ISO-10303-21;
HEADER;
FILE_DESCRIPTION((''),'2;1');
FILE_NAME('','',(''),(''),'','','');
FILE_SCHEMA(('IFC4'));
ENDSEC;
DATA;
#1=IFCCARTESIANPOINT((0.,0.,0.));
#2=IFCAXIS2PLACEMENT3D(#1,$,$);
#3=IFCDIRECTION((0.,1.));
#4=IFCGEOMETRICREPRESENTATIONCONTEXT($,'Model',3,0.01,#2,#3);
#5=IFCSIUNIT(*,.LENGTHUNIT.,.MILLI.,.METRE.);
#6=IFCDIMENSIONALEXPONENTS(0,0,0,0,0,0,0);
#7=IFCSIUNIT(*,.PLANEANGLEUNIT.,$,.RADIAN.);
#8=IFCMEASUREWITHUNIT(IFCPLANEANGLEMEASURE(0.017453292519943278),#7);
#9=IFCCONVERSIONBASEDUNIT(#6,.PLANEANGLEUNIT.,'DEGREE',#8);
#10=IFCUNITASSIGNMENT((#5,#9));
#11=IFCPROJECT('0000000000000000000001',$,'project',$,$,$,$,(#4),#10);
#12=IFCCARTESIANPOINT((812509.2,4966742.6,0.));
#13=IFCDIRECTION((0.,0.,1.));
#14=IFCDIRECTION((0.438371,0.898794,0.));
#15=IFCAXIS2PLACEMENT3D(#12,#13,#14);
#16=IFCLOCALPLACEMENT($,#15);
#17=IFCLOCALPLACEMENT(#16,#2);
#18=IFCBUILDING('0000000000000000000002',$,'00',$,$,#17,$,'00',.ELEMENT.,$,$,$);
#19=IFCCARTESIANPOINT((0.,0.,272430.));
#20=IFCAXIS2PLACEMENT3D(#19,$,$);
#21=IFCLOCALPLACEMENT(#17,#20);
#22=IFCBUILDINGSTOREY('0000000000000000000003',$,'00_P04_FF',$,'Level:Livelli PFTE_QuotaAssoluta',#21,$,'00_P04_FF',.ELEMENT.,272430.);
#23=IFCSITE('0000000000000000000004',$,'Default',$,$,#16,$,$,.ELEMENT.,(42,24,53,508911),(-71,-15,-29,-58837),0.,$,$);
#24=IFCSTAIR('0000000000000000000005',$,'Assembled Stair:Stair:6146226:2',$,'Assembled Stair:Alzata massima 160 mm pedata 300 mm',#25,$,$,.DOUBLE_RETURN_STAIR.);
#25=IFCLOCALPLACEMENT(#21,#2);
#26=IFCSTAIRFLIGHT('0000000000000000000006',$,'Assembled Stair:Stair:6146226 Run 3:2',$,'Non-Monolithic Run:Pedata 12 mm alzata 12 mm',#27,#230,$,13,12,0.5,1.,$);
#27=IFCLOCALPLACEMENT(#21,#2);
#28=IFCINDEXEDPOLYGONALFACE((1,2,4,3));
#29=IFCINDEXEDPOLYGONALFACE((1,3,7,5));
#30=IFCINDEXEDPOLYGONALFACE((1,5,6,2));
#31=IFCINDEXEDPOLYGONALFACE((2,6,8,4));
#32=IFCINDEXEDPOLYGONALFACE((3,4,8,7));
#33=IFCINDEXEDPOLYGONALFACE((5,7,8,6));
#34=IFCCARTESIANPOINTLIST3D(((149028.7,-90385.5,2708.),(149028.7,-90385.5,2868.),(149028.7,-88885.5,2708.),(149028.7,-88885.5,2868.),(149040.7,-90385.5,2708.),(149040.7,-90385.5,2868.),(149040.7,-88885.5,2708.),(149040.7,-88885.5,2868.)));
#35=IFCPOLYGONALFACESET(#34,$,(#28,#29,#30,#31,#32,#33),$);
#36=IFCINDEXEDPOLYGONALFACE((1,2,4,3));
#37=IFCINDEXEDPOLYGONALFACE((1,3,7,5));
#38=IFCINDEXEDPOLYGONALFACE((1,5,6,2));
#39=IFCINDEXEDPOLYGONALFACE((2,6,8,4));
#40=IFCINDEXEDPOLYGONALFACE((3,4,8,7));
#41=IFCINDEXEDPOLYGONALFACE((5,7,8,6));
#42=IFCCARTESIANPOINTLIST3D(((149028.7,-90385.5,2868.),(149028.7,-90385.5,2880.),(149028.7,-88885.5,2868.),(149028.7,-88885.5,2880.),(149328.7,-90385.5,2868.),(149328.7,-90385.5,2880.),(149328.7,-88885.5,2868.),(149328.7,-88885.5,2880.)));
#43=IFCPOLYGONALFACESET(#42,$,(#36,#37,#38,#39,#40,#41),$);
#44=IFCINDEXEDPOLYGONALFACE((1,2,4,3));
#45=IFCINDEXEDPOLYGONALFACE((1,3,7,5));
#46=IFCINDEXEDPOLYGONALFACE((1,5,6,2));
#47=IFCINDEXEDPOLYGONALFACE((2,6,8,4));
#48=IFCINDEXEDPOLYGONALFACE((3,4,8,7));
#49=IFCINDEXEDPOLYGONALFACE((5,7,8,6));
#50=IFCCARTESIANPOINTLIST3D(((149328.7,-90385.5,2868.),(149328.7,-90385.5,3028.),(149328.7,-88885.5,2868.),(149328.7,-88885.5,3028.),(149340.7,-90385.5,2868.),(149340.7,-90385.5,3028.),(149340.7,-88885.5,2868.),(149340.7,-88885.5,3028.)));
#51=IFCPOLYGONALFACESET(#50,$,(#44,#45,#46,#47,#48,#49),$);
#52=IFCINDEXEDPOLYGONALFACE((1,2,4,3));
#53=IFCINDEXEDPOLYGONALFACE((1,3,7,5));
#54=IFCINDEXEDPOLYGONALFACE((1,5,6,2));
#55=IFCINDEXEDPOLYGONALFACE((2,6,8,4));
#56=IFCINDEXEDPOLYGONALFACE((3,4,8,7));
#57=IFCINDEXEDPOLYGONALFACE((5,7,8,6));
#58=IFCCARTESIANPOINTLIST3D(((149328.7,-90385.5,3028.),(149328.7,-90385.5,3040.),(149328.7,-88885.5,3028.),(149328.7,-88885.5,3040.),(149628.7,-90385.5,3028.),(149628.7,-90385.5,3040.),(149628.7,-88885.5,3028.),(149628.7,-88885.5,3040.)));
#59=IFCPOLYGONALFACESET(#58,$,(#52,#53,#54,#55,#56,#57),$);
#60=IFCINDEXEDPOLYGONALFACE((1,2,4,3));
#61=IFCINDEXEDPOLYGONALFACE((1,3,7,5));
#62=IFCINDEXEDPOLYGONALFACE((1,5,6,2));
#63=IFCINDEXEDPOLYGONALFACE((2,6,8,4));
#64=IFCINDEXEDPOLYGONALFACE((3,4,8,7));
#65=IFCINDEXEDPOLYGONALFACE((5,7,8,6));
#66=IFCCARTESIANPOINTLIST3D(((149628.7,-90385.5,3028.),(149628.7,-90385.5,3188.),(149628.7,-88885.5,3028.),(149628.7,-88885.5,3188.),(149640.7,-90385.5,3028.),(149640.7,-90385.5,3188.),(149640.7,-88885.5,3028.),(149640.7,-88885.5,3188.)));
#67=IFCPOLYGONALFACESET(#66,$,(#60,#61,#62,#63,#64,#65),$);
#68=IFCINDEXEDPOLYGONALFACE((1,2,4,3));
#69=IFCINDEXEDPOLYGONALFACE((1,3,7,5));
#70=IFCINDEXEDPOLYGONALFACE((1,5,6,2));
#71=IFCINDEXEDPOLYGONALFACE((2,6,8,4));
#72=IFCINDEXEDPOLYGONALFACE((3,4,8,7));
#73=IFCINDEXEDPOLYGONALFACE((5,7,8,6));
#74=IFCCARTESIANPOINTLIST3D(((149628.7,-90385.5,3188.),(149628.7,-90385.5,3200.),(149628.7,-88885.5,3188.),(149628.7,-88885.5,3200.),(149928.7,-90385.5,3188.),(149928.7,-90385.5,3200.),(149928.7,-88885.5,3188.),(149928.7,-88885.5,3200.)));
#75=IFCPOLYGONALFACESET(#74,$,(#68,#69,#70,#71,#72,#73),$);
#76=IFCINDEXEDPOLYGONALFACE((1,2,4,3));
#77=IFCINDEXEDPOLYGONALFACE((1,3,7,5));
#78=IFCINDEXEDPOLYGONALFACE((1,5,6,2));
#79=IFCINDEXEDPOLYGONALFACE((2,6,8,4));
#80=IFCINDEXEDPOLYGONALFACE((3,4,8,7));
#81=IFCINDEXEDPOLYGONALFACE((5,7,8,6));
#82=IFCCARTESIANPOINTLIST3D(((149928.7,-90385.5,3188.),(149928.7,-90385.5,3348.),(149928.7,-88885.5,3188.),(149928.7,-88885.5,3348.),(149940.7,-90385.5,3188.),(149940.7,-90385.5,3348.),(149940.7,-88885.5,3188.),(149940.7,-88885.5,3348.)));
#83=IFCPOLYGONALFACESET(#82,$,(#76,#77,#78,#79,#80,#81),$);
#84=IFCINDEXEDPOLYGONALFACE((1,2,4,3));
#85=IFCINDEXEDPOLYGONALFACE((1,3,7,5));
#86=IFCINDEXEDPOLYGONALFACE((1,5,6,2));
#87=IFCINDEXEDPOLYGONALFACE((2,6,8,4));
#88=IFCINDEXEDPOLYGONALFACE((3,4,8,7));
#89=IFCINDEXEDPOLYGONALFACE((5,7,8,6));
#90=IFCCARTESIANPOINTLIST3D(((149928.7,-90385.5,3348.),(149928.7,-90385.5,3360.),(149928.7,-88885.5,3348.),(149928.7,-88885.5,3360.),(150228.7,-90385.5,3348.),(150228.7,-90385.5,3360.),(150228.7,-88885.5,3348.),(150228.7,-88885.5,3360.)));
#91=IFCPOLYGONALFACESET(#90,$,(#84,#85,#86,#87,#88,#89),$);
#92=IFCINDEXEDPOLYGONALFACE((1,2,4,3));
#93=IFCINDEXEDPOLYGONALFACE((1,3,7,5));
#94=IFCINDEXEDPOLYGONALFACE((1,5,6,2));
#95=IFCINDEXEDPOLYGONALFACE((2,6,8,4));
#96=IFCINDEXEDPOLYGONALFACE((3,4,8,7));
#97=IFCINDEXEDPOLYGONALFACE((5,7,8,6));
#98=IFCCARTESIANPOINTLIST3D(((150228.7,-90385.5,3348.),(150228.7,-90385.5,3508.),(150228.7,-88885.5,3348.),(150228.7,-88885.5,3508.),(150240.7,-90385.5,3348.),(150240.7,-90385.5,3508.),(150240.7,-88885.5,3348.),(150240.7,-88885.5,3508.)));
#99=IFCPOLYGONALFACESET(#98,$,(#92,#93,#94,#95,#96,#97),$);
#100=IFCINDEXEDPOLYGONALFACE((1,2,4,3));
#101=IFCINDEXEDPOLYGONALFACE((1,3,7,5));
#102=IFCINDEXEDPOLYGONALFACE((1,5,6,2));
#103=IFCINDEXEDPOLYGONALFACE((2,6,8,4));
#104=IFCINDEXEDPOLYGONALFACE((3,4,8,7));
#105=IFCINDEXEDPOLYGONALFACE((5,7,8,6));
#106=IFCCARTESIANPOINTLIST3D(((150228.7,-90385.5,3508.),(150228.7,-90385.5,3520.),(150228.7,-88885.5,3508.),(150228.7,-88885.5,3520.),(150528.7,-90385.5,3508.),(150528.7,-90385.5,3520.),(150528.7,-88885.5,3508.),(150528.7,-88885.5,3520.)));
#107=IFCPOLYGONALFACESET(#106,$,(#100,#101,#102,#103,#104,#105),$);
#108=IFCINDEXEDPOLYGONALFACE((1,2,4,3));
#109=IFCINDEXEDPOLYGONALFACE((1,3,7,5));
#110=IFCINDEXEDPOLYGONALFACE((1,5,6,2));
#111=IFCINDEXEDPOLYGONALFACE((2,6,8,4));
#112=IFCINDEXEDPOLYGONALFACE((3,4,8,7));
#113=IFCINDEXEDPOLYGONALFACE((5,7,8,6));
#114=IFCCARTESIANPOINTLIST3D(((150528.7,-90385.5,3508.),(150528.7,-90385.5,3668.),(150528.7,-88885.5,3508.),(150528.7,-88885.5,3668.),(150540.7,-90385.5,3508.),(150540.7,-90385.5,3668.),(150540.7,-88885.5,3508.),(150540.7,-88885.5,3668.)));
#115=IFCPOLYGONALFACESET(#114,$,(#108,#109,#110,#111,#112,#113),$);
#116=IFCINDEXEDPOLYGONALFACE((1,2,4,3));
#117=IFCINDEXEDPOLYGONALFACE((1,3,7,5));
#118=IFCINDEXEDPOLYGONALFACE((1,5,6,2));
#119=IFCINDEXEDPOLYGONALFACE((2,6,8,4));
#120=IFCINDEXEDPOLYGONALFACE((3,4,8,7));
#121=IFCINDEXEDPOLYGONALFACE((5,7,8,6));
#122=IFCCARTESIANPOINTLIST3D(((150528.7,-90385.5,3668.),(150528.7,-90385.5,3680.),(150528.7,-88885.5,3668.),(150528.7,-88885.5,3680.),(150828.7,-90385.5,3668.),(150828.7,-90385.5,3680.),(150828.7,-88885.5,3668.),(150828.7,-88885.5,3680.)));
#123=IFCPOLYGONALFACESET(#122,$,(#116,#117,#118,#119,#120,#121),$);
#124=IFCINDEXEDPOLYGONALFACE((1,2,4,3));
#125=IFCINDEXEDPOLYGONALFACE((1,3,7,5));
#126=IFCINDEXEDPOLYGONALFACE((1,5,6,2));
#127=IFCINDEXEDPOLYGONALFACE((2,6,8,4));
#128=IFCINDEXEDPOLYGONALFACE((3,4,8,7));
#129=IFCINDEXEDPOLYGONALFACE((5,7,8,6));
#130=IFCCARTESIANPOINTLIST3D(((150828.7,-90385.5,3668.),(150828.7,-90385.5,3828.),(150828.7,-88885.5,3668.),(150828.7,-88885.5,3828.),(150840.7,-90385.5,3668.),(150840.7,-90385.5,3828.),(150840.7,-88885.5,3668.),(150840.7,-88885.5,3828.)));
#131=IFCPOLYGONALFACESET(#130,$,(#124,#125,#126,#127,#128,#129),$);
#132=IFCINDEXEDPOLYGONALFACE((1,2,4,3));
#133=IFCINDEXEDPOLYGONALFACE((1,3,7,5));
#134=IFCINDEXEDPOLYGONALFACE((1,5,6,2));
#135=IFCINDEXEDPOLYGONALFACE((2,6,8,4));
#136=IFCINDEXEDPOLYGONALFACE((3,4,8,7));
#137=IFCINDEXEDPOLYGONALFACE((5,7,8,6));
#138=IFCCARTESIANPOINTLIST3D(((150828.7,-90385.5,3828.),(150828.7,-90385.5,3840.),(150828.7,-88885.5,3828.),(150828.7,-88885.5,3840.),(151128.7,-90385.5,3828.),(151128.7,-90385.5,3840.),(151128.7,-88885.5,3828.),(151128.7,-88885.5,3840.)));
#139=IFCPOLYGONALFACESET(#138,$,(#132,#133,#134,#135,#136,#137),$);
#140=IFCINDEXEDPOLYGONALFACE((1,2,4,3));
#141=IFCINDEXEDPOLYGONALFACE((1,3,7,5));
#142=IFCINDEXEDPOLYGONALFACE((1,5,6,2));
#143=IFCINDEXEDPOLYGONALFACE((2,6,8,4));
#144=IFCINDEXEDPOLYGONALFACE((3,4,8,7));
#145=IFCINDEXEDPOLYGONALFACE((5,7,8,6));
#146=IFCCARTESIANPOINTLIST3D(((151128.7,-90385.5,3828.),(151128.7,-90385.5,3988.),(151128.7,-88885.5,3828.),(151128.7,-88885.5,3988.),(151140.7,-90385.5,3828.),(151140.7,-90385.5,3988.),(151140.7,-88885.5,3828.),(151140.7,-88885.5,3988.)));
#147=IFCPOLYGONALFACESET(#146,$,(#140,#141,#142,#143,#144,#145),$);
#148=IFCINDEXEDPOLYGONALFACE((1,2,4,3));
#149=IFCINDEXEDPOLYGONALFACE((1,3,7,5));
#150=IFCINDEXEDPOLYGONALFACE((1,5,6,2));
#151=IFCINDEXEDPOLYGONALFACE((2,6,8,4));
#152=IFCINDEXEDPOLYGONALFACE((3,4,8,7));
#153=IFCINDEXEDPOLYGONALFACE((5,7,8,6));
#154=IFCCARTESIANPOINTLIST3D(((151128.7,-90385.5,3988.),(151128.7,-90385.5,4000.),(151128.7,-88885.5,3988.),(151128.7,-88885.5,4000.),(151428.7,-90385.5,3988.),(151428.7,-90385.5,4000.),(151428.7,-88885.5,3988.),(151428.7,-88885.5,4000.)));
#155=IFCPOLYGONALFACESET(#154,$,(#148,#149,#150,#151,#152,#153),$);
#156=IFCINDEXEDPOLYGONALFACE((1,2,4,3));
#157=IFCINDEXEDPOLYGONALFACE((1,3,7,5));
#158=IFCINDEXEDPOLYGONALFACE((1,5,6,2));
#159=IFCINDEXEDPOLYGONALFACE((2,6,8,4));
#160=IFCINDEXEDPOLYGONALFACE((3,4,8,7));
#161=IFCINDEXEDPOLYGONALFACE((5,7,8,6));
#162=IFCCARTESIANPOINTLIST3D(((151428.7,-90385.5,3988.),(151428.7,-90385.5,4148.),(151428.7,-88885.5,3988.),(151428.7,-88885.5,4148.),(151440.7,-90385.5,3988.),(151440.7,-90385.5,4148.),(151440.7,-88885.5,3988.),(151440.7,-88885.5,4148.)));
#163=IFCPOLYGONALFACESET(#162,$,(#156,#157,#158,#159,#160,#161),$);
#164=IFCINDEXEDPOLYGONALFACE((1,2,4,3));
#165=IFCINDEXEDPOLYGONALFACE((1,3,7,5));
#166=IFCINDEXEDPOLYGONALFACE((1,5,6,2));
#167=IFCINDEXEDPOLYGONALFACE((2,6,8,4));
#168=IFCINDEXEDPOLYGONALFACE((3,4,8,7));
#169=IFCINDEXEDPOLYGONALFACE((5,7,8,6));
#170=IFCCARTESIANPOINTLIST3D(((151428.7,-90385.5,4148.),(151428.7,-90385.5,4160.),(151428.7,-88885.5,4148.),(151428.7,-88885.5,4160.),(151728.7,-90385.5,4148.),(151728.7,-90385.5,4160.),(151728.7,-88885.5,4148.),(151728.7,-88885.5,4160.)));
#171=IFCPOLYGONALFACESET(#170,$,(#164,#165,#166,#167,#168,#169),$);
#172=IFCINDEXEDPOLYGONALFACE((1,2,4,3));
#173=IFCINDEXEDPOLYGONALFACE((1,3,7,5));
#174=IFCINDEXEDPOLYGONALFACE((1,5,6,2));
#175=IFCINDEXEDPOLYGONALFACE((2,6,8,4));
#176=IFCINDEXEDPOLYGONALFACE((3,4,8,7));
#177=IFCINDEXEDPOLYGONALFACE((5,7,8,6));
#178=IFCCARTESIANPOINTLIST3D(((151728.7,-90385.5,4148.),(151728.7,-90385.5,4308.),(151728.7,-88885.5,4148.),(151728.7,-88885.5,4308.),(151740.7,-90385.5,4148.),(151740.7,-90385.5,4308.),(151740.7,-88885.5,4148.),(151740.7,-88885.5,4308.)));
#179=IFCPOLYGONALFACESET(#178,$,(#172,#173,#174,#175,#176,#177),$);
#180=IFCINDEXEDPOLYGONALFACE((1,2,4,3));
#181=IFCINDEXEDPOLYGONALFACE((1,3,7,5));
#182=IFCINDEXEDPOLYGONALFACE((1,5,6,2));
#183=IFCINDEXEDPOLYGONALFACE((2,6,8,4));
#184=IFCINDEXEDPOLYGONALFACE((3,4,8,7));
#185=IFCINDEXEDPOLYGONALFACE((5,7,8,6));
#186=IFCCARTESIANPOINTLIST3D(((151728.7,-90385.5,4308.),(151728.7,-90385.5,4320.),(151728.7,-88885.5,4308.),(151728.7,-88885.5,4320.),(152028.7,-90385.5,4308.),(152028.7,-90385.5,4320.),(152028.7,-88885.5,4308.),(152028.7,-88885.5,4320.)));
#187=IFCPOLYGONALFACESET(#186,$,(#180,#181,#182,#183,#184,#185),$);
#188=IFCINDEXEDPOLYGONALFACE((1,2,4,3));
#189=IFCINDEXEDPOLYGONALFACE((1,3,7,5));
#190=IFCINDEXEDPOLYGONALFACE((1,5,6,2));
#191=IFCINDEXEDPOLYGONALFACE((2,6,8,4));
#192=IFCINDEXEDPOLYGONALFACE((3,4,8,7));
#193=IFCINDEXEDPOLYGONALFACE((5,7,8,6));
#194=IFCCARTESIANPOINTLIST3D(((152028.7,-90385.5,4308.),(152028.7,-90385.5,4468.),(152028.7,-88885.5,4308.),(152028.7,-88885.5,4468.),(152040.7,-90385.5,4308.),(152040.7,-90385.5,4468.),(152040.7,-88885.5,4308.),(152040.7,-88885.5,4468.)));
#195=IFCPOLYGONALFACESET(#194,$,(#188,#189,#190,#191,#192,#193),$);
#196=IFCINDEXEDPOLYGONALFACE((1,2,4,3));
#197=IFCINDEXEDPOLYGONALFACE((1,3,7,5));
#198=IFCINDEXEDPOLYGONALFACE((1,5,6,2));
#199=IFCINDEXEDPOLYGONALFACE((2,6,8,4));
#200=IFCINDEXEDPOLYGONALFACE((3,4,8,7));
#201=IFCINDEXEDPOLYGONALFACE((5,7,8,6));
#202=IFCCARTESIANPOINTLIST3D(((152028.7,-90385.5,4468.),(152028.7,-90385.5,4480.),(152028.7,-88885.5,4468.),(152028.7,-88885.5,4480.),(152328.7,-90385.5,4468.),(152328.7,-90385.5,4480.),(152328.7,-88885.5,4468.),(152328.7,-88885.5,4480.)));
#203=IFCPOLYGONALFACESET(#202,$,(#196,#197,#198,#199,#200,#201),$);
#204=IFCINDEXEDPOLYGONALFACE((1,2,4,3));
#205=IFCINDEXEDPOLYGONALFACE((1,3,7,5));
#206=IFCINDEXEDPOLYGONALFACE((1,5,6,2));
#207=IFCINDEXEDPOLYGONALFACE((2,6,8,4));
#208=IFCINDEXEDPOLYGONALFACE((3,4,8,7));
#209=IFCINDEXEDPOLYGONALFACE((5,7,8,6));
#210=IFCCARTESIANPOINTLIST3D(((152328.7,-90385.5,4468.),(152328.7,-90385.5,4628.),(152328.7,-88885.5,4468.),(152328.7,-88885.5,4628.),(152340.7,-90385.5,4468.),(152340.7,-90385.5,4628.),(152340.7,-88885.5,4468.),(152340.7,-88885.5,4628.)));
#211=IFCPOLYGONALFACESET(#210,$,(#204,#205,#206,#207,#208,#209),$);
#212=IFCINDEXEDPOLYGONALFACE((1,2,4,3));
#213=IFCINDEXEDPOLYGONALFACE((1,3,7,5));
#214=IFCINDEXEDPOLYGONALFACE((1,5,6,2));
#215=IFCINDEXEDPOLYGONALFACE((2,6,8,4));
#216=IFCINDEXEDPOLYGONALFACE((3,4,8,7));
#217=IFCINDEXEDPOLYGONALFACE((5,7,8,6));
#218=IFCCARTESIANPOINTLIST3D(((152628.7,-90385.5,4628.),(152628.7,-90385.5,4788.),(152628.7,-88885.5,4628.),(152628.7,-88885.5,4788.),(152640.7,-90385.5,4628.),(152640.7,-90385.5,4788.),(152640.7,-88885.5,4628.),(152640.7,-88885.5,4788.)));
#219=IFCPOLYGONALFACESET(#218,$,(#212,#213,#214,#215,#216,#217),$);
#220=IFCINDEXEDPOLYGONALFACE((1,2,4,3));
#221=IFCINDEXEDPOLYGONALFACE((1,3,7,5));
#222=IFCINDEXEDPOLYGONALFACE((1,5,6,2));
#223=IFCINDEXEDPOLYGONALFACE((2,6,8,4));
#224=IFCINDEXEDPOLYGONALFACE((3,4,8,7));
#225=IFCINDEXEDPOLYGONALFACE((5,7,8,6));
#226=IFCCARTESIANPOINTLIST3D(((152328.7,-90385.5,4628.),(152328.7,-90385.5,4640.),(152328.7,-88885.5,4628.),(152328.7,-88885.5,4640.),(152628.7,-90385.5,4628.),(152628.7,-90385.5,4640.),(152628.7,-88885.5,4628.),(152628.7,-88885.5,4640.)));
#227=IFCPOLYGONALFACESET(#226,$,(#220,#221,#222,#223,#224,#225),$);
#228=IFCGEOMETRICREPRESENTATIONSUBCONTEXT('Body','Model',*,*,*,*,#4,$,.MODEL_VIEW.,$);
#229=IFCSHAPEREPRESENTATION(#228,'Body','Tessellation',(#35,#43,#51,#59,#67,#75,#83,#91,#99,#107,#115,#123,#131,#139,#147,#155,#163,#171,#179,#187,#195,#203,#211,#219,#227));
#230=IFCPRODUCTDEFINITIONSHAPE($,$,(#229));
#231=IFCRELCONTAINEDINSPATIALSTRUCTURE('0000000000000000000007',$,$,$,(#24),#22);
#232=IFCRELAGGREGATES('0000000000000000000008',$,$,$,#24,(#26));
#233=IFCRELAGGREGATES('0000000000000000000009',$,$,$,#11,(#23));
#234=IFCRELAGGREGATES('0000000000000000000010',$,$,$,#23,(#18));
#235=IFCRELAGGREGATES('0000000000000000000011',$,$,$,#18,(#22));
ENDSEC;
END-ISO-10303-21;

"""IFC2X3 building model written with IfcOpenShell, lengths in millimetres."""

from ifc_helpers import new_model, entity, si_unit, converted_unit, direction, frame, origin, origin_2d_with_axis, place, context, subcontext, project, spatial, rectangle, extrude, element, aggregate, save


model = new_model("IFC2X3")

# Units and contexts
model_context = context("Model", 3, precision=0.01, world=origin(), true_north=direction((0.0, 1.0)))
body_context = subcontext(model_context, "Body", "Model", "MODEL_VIEW")
ifc_project = project(units=[si_unit("LENGTHUNIT", "METRE", prefix="MILLI"), converted_unit("PLANEANGLEUNIT", "DEGREE", entity("IfcPlaneAngleMeasure", 0.017453292519943278), si_unit("PLANEANGLEUNIT", "RADIAN"), dimensions=[0, 0, 0, 0, 0, 0, 0])], contexts=[model_context])

# Site, building, storey
site_placement = place(None, frame((812509.2, 4966742.6, 0.0), z_axis=(0.0, 0.0, 1.0), x_axis=(0.438371, 0.898794, 0.0)))
site = spatial("IfcSite", under=ifc_project, at=site_placement, Name="Default", CompositionType="ELEMENT", RefLatitude=(42, 24, 53, 508911), RefLongitude=(-71, -15, -29, -58837), RefElevation=0.0)
building_placement = place(site_placement, origin())
building = spatial("IfcBuilding", under=site, at=building_placement, Name="00", LongName="00", CompositionType="ELEMENT")
storey_placement = place(building_placement, frame((0.0, 0.0, 272430.0)))
storey = spatial("IfcBuildingStorey", under=building, at=storey_placement, Name="00_P04_FF", ObjectType="Level:Livelli PFTE_QuotaAssoluta", LongName="00_P04_FF", CompositionType="ELEMENT", Elevation=272430.0)

# Stair
stair_1_placement = place(storey_placement, origin())
stair_1 = element("IfcStair", 1, at=stair_1_placement, inside=storey, Name="Assembled Stair:Stair:6146226:2", ObjectType="Assembled Stair:Alzata massima 160 mm pedata 300 mm", ShapeType="DOUBLE_RETURN_STAIR")

# Stair flight
stair_flight_1_placement = place(stair_1_placement, origin())
stair_flight_1 = element("IfcStairFlight", 2, at=stair_flight_1_placement, Name="Assembled Stair:Stair:6146226 Run 3:2", ObjectType="Non-Monolithic Run:Pedata 12 mm alzata 12 mm", NumberOfRiser=13, NumberOfTreads=12, RiserHeight=0.5, TreadLength=1.0, context=body_context, shape_type="SweptSolid", body=[
    extrude(rectangle(XDim=1500.0, YDim=12.0, at=origin_2d_with_axis()), frame((149034.7, -89635.5, 2708.0), z_axis=(0.0, 0.0, 1.0), x_axis=(0.0, 1.0, 0.0)), (0.0, 0.0, 1.0), 160.0),
    extrude(rectangle(XDim=300.0, YDim=1500.0, at=origin_2d_with_axis()), frame((149178.7, -89635.5, 2868.0), z_axis=(0.0, 0.0, 1.0), x_axis=(-1.0, 0.0, 0.0)), (0.0, 0.0, 1.0), 12.0),
    extrude(rectangle(XDim=1500.0, YDim=12.0, at=origin_2d_with_axis()), frame((149334.7, -89635.5, 2868.0), z_axis=(0.0, 0.0, 1.0), x_axis=(0.0, 1.0, 0.0)), (0.0, 0.0, 1.0), 160.0),
    extrude(rectangle(XDim=300.0, YDim=1500.0, at=origin_2d_with_axis()), frame((149478.7, -89635.5, 3028.0), z_axis=(0.0, 0.0, 1.0), x_axis=(-1.0, 0.0, 0.0)), (0.0, 0.0, 1.0), 12.0),
    extrude(rectangle(XDim=1500.0, YDim=12.0, at=origin_2d_with_axis()), frame((149634.7, -89635.5, 3028.0), z_axis=(0.0, 0.0, 1.0), x_axis=(0.0, 1.0, 0.0)), (0.0, 0.0, 1.0), 160.0),
    extrude(rectangle(XDim=300.0, YDim=1500.0, at=origin_2d_with_axis()), frame((149778.7, -89635.5, 3188.0), z_axis=(0.0, 0.0, 1.0), x_axis=(-1.0, 0.0, 0.0)), (0.0, 0.0, 1.0), 12.0),
    extrude(rectangle(XDim=1500.0, YDim=12.0, at=origin_2d_with_axis()), frame((149934.7, -89635.5, 3188.0), z_axis=(0.0, 0.0, 1.0), x_axis=(0.0, 1.0, 0.0)), (0.0, 0.0, 1.0), 160.0),
    extrude(rectangle(XDim=300.0, YDim=1500.0, at=origin_2d_with_axis()), frame((150078.7, -89635.5, 3348.0), z_axis=(0.0, 0.0, 1.0), x_axis=(-1.0, 0.0, 0.0)), (0.0, 0.0, 1.0), 12.0),
    extrude(rectangle(XDim=1500.0, YDim=12.0, at=origin_2d_with_axis()), frame((150234.7, -89635.5, 3348.0), z_axis=(0.0, 0.0, 1.0), x_axis=(0.0, 1.0, 0.0)), (0.0, 0.0, 1.0), 160.0),
    extrude(rectangle(XDim=300.0, YDim=1500.0, at=origin_2d_with_axis()), frame((150378.7, -89635.5, 3508.0), z_axis=(0.0, 0.0, 1.0), x_axis=(-1.0, 0.0, 0.0)), (0.0, 0.0, 1.0), 12.0),
    extrude(rectangle(XDim=1500.0, YDim=12.0, at=origin_2d_with_axis()), frame((150534.7, -89635.5, 3508.0), z_axis=(0.0, 0.0, 1.0), x_axis=(0.0, 1.0, 0.0)), (0.0, 0.0, 1.0), 160.0),
    extrude(rectangle(XDim=300.0, YDim=1500.0, at=origin_2d_with_axis()), frame((150678.7, -89635.5, 3668.0), z_axis=(0.0, 0.0, 1.0), x_axis=(-1.0, 0.0, 0.0)), (0.0, 0.0, 1.0), 12.0),
    extrude(rectangle(XDim=1500.0, YDim=12.0, at=origin_2d_with_axis()), frame((150834.7, -89635.5, 3668.0), z_axis=(0.0, 0.0, 1.0), x_axis=(0.0, 1.0, 0.0)), (0.0, 0.0, 1.0), 160.0),
    extrude(rectangle(XDim=300.0, YDim=1500.0, at=origin_2d_with_axis()), frame((150978.7, -89635.5, 3828.0), z_axis=(0.0, 0.0, 1.0), x_axis=(-1.0, 0.0, 0.0)), (0.0, 0.0, 1.0), 12.0),
    extrude(rectangle(XDim=1500.0, YDim=12.0, at=origin_2d_with_axis()), frame((151134.7, -89635.5, 3828.0), z_axis=(0.0, 0.0, 1.0), x_axis=(0.0, 1.0, 0.0)), (0.0, 0.0, 1.0), 160.0),
    extrude(rectangle(XDim=300.0, YDim=1500.0, at=origin_2d_with_axis()), frame((151278.7, -89635.5, 3988.0), z_axis=(0.0, 0.0, 1.0), x_axis=(-1.0, 0.0, 0.0)), (0.0, 0.0, 1.0), 12.0),
    extrude(rectangle(XDim=1500.0, YDim=12.0, at=origin_2d_with_axis()), frame((151434.7, -89635.5, 3988.0), z_axis=(0.0, 0.0, 1.0), x_axis=(0.0, 1.0, 0.0)), (0.0, 0.0, 1.0), 160.0),
    extrude(rectangle(XDim=300.0, YDim=1500.0, at=origin_2d_with_axis()), frame((151578.7, -89635.5, 4148.0), z_axis=(0.0, 0.0, 1.0), x_axis=(-1.0, 0.0, 0.0)), (0.0, 0.0, 1.0), 12.0),
    extrude(rectangle(XDim=1500.0, YDim=12.0, at=origin_2d_with_axis()), frame((151734.7, -89635.5, 4148.0), z_axis=(0.0, 0.0, 1.0), x_axis=(0.0, 1.0, 0.0)), (0.0, 0.0, 1.0), 160.0),
    extrude(rectangle(XDim=300.0, YDim=1500.0, at=origin_2d_with_axis()), frame((151878.7, -89635.5, 4308.0), z_axis=(0.0, 0.0, 1.0), x_axis=(-1.0, 0.0, 0.0)), (0.0, 0.0, 1.0), 12.0),
    extrude(rectangle(XDim=1500.0, YDim=12.0, at=origin_2d_with_axis()), frame((152034.7, -89635.5, 4308.0), z_axis=(0.0, 0.0, 1.0), x_axis=(0.0, 1.0, 0.0)), (0.0, 0.0, 1.0), 160.0),
    extrude(rectangle(XDim=300.0, YDim=1500.0, at=origin_2d_with_axis()), frame((152178.7, -89635.5, 4468.0), z_axis=(0.0, 0.0, 1.0), x_axis=(-1.0, 0.0, 0.0)), (0.0, 0.0, 1.0), 12.0),
    extrude(rectangle(XDim=1500.0, YDim=12.0, at=origin_2d_with_axis()), frame((152334.7, -89635.5, 4468.0), z_axis=(0.0, 0.0, 1.0), x_axis=(0.0, 1.0, 0.0)), (0.0, 0.0, 1.0), 160.0),
    extrude(rectangle(XDim=1500.0, YDim=12.0, at=origin_2d_with_axis()), frame((152634.7, -89635.5, 4628.0), z_axis=(0.0, 0.0, 1.0), x_axis=(0.0, 1.0, 0.0)), (0.0, 0.0, 1.0), 160.0),
    extrude(rectangle(XDim=300.0, YDim=1500.0, at=origin_2d_with_axis()), frame((152478.7, -89635.5, 4628.0), z_axis=(0.0, 0.0, 1.0), x_axis=(-1.0, 0.0, 0.0)), (0.0, 0.0, 1.0), 12.0),
])
aggregate(stair_1, [stair_flight_1])

save(model, "model.ifc")
